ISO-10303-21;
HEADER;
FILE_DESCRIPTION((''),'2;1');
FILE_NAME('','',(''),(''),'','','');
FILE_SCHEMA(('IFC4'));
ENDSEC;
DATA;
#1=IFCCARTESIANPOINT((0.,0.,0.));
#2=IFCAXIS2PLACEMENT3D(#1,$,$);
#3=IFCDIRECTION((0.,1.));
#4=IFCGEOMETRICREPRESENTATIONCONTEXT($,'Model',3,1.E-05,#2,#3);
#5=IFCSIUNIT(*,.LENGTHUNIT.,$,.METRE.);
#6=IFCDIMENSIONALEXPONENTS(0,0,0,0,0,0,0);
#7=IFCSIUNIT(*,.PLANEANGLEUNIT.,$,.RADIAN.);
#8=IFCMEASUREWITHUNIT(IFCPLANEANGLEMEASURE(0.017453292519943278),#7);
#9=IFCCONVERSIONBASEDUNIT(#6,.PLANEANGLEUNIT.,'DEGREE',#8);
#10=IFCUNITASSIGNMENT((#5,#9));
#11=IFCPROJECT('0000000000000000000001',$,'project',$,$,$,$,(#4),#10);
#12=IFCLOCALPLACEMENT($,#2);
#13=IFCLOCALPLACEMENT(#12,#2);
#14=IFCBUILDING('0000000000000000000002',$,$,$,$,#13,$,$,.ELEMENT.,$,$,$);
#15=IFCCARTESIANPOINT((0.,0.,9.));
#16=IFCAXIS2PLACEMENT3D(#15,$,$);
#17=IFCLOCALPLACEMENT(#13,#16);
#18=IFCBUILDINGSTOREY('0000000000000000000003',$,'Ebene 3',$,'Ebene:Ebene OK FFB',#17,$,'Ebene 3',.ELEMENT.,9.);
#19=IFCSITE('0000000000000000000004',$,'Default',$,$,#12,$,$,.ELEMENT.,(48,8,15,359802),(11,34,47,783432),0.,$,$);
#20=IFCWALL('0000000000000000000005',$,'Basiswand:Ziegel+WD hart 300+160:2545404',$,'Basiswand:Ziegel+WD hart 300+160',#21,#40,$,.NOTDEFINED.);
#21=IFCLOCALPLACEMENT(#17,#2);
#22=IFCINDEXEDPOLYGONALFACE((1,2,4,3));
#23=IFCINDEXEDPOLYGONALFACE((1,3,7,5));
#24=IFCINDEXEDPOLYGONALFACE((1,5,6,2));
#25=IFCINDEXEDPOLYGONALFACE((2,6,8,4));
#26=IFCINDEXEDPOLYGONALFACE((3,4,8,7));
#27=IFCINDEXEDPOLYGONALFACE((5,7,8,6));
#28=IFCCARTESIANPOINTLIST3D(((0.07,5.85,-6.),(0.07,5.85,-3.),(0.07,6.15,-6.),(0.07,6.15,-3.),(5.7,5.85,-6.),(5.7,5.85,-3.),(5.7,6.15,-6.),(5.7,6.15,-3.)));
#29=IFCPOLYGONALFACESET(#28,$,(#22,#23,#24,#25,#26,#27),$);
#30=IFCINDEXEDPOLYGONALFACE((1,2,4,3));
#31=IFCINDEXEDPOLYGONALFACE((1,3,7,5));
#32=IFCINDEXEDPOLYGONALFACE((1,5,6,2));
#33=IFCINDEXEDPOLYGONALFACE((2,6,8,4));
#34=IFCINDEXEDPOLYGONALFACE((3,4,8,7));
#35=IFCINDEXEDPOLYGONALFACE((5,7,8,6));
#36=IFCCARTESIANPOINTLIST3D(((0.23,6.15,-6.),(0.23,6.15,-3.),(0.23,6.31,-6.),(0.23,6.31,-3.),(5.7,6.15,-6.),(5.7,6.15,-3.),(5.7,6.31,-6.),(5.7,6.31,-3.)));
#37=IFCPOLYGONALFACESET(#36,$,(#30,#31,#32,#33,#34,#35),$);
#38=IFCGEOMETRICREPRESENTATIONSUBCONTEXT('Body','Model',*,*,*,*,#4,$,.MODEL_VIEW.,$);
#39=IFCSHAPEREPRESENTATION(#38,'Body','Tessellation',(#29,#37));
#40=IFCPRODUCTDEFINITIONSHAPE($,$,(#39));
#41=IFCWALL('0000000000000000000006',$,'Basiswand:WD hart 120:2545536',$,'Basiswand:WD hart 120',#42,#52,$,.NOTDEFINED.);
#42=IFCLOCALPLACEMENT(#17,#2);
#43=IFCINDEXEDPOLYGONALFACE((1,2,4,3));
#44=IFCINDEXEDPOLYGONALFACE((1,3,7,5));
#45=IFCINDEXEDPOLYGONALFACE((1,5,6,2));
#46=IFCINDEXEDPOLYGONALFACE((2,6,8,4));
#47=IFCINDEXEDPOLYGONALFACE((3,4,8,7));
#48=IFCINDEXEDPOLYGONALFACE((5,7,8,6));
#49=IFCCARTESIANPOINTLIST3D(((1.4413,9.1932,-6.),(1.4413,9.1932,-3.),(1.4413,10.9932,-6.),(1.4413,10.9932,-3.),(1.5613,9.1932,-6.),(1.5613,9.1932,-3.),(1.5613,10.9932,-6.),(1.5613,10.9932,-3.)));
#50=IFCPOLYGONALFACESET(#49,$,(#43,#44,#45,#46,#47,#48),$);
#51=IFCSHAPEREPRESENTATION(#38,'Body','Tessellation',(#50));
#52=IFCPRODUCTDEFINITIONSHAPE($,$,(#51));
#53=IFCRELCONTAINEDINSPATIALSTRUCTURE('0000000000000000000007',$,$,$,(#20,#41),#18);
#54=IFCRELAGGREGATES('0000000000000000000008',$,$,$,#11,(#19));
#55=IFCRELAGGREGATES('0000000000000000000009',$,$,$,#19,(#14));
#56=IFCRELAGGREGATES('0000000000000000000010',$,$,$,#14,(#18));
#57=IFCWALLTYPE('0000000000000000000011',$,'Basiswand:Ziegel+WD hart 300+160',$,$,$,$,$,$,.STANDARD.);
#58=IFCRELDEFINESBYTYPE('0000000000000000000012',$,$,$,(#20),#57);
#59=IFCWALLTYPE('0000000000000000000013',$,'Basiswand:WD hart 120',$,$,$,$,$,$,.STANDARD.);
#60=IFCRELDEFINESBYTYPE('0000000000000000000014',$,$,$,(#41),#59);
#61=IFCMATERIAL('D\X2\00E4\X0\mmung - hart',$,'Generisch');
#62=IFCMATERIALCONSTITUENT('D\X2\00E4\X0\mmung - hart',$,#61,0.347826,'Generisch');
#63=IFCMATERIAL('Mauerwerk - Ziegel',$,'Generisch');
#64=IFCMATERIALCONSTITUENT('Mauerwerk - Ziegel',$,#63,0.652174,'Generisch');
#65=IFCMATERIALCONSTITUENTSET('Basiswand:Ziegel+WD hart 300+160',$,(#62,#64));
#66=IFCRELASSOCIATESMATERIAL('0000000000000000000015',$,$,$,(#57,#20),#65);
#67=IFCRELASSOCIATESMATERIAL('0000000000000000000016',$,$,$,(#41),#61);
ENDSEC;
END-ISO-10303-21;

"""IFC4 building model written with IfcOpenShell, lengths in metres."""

from ifc_helpers import new_model, entity, si_unit, converted_unit, direction, frame, origin, place, context, subcontext, project, spatial, indexed_curve, outline, extrude, material, constituent, constituent_set, type_object, element, save


model = new_model("IFC4")

# Units and contexts
model_context = context("Model", 3, precision=1e-05, world=origin(), true_north=direction((0.0, 1.0)))
body_context = subcontext(model_context, "Body", "Model", "MODEL_VIEW")
ifc_project = project(units=[si_unit("LENGTHUNIT", "METRE"), converted_unit("PLANEANGLEUNIT", "DEGREE", entity("IfcPlaneAngleMeasure", 0.017453292519943278), si_unit("PLANEANGLEUNIT", "RADIAN"), dimensions=[0, 0, 0, 0, 0, 0, 0])], contexts=[model_context])

# Site, building, storey
site_placement = place(None, origin())
site = spatial("IfcSite", under=ifc_project, at=site_placement, Name="Default", CompositionType="ELEMENT", RefLatitude=(48, 8, 15, 359802), RefLongitude=(11, 34, 47, 783432), RefElevation=0.0)
building_placement = place(site_placement, origin())
building = spatial("IfcBuilding", under=site, at=building_placement, CompositionType="ELEMENT")
storey_placement = place(building_placement, frame((0.0, 0.0, 9.0)))
storey = spatial("IfcBuildingStorey", under=building, at=storey_placement, Name="Ebene 3", ObjectType="Ebene:Ebene OK FFB", LongName="Ebene 3", CompositionType="ELEMENT", Elevation=9.0)

# Shared definitions
ifc_material_1 = material(Name="Dämmung - hart", Category="Generisch")
ifc_constituent_1 = constituent(ifc_material_1, Name="Dämmung - hart", Category="Generisch", fraction=0.347826)
ifc_material_2 = material(Name="Mauerwerk - Ziegel", Category="Generisch")
ifc_constituent_2 = constituent(ifc_material_2, Name="Mauerwerk - Ziegel", Category="Generisch", fraction=0.652174)
ifc_constituent_set_1 = constituent_set(constituents=[ifc_constituent_1, ifc_constituent_2], Name="Basiswand:Ziegel+WD hart 300+160")
wall_type_1 = type_object("IfcWallType", Name="Basiswand:Ziegel+WD hart 300+160", PredefinedType="STANDARD", material=ifc_constituent_set_1)

# Walls
wall_1_placement = place(storey_placement, frame((0.23, 6.08, -6.0)))
element("IfcWall", 1, at=wall_1_placement, inside=storey, type_object=wall_type_1, material=ifc_constituent_set_1, Name="Basiswand:Ziegel+WD hart 300+160:2545404", ObjectType="Basiswand:Ziegel+WD hart 300+160", PredefinedType="NOTDEFINED", context=body_context, shape_type="SweptSolid", body=[
    extrude(outline(indexed_curve([(-0.15, -2.815), (0.15, -2.815), (0.15, 2.815), (-0.15, 2.815), (-0.15, -2.815)], self_intersect=False)), frame((2.655, -0.08, 0.0), z_axis=(0.0, 0.0, 1.0), x_axis=(0.0, 1.0, 0.0)), (0.0, 0.0, 1.0), 3.0),
    extrude(outline(indexed_curve([(-0.08, -2.735), (0.08, -2.735), (0.08, 2.735), (-0.08, 2.735), (-0.08, -2.735)], self_intersect=False)), frame((2.735, 0.15, 0.0), z_axis=(0.0, 0.0, 1.0), x_axis=(0.0, 1.0, 0.0)), (0.0, 0.0, 1.0), 3.0),
])
wall_type_2 = type_object("IfcWallType", Name="Basiswand:WD hart 120", PredefinedType="STANDARD")
wall_2_placement = place(storey_placement, frame((1.5013, 10.9932, -6.0), z_axis=(0.0, 0.0, 1.0), x_axis=(0.0, -1.0, 0.0)))
element("IfcWall", 2, at=wall_2_placement, inside=storey, type_object=wall_type_2, material=ifc_material_1, Name="Basiswand:WD hart 120:2545536", ObjectType="Basiswand:WD hart 120", PredefinedType="NOTDEFINED", context=body_context, shape_type="SweptSolid", body=[
    extrude(outline(indexed_curve([(1.8, 0.06), (0.0, 0.06), (0.0, -0.06), (1.8, -0.06), (1.8, 0.06)], self_intersect=False)), origin(), (0.0, 0.0, 1.0), 3.0),
])

save(model, "model.ifc")
